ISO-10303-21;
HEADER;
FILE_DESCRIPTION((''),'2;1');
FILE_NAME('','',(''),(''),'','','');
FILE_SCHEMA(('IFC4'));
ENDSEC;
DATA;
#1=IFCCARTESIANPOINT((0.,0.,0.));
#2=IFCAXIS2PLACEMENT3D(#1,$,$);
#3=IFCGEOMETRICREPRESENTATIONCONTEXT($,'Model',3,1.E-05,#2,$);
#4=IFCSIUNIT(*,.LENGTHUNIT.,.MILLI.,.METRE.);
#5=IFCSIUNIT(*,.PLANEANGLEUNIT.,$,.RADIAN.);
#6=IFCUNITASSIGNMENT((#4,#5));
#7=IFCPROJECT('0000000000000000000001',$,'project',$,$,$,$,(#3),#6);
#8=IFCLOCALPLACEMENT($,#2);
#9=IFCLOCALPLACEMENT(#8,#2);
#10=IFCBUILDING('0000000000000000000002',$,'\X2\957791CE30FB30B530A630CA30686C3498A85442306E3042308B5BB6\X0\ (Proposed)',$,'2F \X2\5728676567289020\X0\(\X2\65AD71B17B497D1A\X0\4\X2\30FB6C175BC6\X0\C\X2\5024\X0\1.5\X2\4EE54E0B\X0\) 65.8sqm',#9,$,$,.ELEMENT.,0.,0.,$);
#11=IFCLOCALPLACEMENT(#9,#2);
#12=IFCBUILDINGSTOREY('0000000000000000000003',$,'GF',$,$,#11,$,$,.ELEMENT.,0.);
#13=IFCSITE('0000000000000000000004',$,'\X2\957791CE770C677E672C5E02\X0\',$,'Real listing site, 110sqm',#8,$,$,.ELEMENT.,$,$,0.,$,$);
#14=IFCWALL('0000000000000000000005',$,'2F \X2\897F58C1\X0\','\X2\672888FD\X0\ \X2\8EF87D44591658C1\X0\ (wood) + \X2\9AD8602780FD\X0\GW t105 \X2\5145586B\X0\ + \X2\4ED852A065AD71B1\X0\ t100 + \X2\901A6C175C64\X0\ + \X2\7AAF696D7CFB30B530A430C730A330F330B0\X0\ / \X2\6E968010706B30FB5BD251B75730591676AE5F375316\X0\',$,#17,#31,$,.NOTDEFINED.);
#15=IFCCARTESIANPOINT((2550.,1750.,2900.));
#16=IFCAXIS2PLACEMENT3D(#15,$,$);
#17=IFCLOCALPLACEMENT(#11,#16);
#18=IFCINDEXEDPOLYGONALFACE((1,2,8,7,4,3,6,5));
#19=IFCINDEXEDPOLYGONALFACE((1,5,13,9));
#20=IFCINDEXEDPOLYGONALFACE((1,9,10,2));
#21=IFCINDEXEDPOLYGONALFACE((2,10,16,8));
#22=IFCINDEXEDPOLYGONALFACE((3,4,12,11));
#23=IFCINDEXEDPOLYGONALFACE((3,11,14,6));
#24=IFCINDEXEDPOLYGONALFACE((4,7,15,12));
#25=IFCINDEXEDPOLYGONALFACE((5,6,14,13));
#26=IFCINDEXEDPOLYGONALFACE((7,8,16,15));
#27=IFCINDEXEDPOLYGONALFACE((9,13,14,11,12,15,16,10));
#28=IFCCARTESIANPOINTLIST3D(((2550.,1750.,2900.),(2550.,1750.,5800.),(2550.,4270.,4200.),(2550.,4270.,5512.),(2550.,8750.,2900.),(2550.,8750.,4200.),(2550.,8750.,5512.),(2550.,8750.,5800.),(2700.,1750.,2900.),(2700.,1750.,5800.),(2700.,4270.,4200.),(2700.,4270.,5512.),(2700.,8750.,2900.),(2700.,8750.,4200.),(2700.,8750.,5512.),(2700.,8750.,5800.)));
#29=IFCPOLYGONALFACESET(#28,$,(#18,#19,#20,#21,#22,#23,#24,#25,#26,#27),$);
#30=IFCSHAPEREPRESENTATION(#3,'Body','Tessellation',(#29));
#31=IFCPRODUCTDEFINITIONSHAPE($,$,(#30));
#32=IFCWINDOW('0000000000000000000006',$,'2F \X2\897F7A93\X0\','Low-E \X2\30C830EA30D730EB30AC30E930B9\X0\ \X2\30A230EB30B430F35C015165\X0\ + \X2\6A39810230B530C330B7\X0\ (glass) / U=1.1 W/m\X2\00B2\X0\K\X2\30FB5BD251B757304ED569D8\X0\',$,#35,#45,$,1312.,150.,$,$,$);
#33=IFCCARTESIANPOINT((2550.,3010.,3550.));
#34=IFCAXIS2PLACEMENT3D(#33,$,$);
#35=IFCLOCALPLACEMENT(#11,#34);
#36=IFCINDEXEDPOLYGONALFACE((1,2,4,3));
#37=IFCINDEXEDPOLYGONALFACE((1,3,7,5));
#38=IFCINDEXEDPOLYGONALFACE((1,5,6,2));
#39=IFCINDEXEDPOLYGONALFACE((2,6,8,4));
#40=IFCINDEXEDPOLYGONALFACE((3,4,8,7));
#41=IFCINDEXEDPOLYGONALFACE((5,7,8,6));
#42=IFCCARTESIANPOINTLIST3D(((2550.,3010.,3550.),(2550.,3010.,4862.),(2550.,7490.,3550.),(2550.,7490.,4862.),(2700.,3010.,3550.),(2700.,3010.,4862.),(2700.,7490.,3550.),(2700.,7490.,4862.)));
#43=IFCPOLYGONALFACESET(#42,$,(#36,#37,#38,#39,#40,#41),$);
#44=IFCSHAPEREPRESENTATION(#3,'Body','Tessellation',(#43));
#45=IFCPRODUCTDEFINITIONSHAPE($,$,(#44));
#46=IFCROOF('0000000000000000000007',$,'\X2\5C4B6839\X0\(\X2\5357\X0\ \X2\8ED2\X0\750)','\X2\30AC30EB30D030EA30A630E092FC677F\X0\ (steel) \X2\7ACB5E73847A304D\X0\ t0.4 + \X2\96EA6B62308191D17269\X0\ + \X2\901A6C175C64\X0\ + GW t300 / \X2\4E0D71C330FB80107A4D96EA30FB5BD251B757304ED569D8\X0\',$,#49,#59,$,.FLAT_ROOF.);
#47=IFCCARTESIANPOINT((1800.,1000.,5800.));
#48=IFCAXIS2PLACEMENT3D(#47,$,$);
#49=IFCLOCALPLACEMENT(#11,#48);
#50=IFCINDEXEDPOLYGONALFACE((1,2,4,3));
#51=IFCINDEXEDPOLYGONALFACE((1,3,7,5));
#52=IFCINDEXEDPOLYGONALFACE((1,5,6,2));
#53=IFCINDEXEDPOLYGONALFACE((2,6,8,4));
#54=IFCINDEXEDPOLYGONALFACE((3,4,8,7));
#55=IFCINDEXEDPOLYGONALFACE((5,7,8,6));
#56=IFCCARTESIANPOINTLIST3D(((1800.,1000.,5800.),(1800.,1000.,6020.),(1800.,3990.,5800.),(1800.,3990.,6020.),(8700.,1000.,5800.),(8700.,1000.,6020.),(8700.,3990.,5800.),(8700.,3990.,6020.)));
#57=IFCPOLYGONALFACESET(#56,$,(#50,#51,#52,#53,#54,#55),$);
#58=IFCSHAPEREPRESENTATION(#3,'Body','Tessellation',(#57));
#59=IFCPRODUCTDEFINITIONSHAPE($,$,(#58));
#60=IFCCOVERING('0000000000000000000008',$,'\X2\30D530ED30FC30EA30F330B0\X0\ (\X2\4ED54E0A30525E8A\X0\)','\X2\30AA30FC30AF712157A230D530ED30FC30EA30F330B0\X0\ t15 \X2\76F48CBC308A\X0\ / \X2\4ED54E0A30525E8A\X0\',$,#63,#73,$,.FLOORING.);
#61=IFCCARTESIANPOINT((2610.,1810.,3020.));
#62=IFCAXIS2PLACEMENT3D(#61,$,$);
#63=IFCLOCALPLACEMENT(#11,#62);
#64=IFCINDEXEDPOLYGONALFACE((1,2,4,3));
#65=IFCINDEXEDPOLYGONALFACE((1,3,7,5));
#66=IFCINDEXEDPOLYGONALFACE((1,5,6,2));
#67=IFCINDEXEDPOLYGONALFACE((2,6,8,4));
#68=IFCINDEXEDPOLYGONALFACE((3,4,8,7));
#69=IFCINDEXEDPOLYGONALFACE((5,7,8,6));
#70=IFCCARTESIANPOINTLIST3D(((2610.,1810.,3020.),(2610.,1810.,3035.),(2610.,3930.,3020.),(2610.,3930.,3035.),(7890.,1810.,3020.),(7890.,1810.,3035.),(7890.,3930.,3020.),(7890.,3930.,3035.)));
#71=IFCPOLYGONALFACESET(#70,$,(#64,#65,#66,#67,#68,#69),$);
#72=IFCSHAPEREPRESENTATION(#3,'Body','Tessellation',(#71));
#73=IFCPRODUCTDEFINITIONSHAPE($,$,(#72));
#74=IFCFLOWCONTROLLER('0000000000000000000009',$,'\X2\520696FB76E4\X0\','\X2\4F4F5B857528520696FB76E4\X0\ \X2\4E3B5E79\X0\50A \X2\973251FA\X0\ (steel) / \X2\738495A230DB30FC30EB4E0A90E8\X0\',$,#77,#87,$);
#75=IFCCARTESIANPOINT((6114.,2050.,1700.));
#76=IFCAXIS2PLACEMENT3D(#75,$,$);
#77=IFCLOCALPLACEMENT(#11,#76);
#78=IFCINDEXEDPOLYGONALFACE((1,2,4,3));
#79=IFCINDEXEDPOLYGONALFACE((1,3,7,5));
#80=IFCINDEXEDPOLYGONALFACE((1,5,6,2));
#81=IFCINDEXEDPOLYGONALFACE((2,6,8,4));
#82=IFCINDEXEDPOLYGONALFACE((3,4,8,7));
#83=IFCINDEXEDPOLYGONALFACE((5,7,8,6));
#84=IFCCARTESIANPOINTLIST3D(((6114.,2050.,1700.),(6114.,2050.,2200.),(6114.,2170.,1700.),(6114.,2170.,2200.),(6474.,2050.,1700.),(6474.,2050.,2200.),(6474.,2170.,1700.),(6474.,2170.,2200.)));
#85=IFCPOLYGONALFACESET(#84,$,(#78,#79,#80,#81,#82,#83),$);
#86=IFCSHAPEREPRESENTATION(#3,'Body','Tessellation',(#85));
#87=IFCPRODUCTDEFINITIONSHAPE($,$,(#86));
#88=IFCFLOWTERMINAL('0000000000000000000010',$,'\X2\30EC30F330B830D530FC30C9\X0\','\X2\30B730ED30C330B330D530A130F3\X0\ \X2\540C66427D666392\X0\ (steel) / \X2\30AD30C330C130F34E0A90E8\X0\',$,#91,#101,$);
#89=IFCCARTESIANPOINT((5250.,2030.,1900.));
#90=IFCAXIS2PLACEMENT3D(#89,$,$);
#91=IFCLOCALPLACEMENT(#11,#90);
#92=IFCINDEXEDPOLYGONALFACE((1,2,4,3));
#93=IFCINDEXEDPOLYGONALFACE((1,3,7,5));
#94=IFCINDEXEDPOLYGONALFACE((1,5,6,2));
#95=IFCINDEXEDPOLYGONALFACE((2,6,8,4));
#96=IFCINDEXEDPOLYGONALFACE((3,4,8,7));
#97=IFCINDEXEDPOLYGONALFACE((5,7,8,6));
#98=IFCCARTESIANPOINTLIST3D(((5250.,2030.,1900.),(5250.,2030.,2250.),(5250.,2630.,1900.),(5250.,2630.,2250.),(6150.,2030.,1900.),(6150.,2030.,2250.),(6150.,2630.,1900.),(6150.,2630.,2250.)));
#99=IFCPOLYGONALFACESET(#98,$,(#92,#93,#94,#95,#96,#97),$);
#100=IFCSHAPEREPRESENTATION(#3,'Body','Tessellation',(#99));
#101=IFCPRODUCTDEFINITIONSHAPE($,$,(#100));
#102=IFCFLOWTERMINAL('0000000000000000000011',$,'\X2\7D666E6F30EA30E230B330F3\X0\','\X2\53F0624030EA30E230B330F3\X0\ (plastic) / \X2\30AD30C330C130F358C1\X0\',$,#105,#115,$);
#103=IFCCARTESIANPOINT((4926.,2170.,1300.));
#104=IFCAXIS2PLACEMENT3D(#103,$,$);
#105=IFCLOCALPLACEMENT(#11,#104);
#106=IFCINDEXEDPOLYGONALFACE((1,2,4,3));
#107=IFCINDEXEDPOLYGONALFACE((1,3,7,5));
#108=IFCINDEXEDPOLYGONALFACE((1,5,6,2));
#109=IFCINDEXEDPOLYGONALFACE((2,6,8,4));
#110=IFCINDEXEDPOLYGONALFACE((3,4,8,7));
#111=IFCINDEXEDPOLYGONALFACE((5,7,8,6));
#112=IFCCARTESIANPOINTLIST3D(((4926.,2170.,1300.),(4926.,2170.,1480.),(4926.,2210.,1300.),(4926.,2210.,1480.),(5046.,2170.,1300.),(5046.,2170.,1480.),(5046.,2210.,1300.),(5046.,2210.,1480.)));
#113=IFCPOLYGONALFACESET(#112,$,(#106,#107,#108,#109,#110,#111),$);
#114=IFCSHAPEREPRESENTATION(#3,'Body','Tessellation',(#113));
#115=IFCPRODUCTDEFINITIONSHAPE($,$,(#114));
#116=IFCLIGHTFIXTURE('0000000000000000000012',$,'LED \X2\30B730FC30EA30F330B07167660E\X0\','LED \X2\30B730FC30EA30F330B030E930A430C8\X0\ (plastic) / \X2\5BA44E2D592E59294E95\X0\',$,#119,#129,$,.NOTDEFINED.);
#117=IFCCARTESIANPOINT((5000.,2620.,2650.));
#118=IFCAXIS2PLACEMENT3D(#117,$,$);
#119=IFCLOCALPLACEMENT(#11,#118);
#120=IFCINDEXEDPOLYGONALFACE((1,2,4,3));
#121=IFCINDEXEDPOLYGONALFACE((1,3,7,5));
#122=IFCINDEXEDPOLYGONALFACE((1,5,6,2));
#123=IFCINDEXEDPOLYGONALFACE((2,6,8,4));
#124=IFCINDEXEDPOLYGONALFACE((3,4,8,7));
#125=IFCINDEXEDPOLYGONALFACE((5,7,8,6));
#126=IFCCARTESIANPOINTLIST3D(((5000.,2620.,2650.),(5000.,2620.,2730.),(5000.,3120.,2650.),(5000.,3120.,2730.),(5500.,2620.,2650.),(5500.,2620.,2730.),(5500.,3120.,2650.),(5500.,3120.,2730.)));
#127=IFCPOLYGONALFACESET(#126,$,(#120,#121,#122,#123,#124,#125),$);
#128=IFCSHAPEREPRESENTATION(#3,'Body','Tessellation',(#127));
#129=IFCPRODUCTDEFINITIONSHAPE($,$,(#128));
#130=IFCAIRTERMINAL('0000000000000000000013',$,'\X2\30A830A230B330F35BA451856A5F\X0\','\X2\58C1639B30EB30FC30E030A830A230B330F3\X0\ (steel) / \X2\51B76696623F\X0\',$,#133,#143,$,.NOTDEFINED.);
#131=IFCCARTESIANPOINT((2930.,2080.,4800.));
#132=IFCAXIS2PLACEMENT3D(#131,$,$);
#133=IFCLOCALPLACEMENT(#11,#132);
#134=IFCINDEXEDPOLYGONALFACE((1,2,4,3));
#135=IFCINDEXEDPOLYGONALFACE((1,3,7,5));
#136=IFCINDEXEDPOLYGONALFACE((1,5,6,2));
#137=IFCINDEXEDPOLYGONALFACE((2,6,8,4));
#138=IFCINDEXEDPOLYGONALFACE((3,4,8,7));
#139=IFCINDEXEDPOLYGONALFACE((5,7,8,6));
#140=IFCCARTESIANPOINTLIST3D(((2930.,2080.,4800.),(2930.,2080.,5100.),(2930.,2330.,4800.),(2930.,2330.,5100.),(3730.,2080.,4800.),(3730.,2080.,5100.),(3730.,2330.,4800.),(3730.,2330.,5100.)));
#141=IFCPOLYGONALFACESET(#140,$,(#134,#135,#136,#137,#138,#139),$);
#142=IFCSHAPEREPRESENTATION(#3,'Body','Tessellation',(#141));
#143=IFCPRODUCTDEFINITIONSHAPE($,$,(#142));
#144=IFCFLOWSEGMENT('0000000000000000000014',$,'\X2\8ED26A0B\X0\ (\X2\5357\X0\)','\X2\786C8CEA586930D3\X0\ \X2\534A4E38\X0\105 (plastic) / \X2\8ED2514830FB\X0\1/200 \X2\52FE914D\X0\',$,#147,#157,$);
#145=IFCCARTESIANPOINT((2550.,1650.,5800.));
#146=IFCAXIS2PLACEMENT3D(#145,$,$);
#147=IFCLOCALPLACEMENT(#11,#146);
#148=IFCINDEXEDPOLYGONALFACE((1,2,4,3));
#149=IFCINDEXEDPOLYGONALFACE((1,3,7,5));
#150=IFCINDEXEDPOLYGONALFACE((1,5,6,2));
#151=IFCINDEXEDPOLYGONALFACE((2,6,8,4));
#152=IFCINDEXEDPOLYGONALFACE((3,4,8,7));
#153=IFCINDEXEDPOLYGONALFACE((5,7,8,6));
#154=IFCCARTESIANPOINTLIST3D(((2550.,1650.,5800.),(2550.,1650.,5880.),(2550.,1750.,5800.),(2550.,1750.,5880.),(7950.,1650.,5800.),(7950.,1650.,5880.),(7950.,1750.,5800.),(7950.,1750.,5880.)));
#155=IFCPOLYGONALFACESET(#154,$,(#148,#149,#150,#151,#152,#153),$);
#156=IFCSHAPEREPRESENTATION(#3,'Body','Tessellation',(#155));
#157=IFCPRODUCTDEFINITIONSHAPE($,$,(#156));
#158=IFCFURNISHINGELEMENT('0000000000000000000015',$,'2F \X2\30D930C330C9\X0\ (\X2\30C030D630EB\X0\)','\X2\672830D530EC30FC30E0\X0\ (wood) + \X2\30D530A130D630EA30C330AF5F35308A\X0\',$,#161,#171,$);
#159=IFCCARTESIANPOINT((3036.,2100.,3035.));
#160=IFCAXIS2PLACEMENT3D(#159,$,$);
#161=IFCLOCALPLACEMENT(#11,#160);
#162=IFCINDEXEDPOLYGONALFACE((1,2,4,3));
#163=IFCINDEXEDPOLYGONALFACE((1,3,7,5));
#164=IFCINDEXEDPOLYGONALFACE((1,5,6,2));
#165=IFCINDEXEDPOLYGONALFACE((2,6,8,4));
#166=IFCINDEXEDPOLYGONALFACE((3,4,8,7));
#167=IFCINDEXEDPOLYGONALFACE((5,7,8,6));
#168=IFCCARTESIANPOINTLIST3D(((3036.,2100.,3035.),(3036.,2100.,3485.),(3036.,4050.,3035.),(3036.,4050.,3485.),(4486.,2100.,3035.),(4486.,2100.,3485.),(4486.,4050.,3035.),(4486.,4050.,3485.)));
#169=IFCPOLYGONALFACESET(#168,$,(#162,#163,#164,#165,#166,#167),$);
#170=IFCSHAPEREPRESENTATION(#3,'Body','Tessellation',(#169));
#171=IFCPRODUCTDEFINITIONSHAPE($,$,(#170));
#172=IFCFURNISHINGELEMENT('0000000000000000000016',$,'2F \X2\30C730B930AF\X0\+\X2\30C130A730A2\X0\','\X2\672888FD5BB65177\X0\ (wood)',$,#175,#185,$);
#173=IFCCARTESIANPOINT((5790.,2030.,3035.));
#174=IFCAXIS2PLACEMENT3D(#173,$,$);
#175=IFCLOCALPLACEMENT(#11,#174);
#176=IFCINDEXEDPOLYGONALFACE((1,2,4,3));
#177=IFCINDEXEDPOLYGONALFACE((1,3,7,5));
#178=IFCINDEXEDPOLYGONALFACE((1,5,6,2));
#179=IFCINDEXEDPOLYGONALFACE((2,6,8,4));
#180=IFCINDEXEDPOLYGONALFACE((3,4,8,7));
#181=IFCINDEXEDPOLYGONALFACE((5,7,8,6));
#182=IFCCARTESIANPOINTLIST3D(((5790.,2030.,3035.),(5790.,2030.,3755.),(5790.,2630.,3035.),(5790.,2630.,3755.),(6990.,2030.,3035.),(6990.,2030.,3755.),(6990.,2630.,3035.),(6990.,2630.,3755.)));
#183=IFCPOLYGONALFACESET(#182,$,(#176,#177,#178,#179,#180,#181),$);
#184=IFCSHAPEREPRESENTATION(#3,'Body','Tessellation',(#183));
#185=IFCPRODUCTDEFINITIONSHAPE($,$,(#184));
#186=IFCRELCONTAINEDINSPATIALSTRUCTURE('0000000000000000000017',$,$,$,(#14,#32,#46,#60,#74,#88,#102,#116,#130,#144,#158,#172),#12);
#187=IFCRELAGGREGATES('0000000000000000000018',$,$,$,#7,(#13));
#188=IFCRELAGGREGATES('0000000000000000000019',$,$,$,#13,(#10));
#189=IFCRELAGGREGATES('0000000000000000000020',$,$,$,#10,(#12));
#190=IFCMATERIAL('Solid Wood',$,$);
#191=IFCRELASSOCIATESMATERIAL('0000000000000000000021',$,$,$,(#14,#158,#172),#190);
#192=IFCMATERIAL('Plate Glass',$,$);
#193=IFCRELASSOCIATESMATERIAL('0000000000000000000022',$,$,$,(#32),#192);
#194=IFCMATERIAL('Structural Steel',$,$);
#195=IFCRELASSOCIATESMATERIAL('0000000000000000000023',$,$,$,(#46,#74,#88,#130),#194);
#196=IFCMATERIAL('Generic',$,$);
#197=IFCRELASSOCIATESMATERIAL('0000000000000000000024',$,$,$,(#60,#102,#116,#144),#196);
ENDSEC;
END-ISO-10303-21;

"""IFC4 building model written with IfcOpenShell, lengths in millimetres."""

from ifc_helpers import new_model, si_unit, frame, frame_2d, origin, place, context, project, spatial, rectangle, extrude, material, element, fill, save


model = new_model("IFC4")

# Units and contexts
model_context = context("Model", 3, precision=1e-05, world=origin())
ifc_project = project(units=[si_unit("LENGTHUNIT", "METRE", prefix="MILLI"), si_unit("PLANEANGLEUNIT", "RADIAN")], contexts=[model_context])

# Site, building, storey
site_placement = place(None, origin())
site = spatial("IfcSite", under=ifc_project, at=site_placement, Name="長野県松本市", ObjectType="Real listing site, 110sqm", CompositionType="ELEMENT", RefElevation=0.0)
building_placement = place(site_placement, origin())
building = spatial("IfcBuilding", under=site, at=building_placement, Name="長野・サウナと水風呂のある家 (Proposed)", ObjectType="2F 在来木造(断熱等級4・気密C値1.5以下) 65.8sqm", CompositionType="ELEMENT", ElevationOfRefHeight=0.0, ElevationOfTerrain=0.0)
storey_placement = place(building_placement, origin())
storey = spatial("IfcBuildingStorey", under=building, at=storey_placement, Name="GF", CompositionType="ELEMENT", Elevation=0.0)

# Shared definitions
ifc_material_1 = material(Name="Solid Wood")

# Wall, opening, window
ifc_material_2 = material(Name="Plate Glass")
wall_1_placement = place(storey_placement, frame((2550.0, 1750.0, 2900.0)))
wall_1 = element("IfcWall", 1, at=wall_1_placement, inside=storey, material=ifc_material_1, Name="2F 西壁", Description="木製 軸組外壁 (wood) + 高性能GW t105 充填 + 付加断熱 t100 + 通気層 + 窯業系サイディング / 準耐火・寒冷地外皮強化", PredefinedType="NOTDEFINED", context=model_context, shape_type="SweptSolid", body=[
    extrude(rectangle(XDim=150.0, YDim=7000.0, at=frame_2d((75.0, 3500.0))), frame((2550.0, 1750.0, 2900.0)), (0.0, 0.0, 1.0), 2900.0),
])
opening_1_placement = place(storey_placement, frame((2550.0, 3010.0, 3550.0)))
opening_1 = element("IfcOpeningElement", 2, at=opening_1_placement, cuts=wall_1, PredefinedType="NOTDEFINED", context=model_context, shape_type="SweptSolid", body=[
    extrude(rectangle(XDim=150.0, YDim=4480.0, at=frame_2d((75.0, 2240.0))), frame((2550.0, 3010.0, 3550.0)), (0.0, 0.0, 1.0), 1312.0),
])
window_1_placement = place(storey_placement, frame((2550.0, 3010.0, 3550.0)))
window_1 = element("IfcWindow", 3, at=window_1_placement, inside=storey, material=ifc_material_2, Name="2F 西窓", Description="Low-E トリプルガラス アルゴン封入 + 樹脂サッシ (glass) / U=1.1 W/m²K・寒冷地仕様", OverallHeight=1312.0, OverallWidth=150.0, context=model_context, shape_type="SweptSolid", body=[
    extrude(rectangle(XDim=150.0, YDim=4480.0, at=frame_2d((75.0, 2240.0))), frame((2550.0, 3010.0, 3550.0)), (0.0, 0.0, 1.0), 1312.0),
])
fill(opening_1, window_1)

# Roof
ifc_material_3 = material(Name="Structural Steel")
for number, where, name in (
    (4, (1800.0, 1000.0, 5800.0), "屋根(南 軒750)"),
):
    element("IfcRoof", number, at=place(storey_placement, frame(where)), inside=storey, material=ifc_material_3, Name=name, Description="ガルバリウム鋼板 (steel) 立平葺き t0.4 + 雪止め金物 + 通気層 + GW t300 / 不燃・耐積雪・寒冷地仕様", PredefinedType="FLAT_ROOF", context=model_context, shape_type="SweptSolid", body=[
        extrude(rectangle(XDim=6900.0, YDim=2990.0, at=frame_2d((3450.0, 1495.0))), frame((1800.0, 1000.0, 5800.0)), (0.0, 0.0, 1.0), 220.0),
    ])

# Covering
ifc_material_4 = material(Name="Generic")
covering_placement = place(storey_placement, frame((2610.0, 1810.0, 3020.0)))
element("IfcCovering", 5, at=covering_placement, inside=storey, material=ifc_material_4, Name="フローリング (仕上げ床)", Description="オーク無垢フローリング t15 直貼り / 仕上げ床", PredefinedType="FLOORING", context=model_context, shape_type="SweptSolid", body=[
    extrude(rectangle(XDim=5280.0, YDim=2120.0, at=frame_2d((2640.0, 1060.0))), frame((2610.0, 1810.0, 3020.0)), (0.0, 0.0, 1.0), 15.0),
])

# Flow controller
flow_controller_placement = place(storey_placement, frame((6114.0, 2050.0, 1700.0)))
element("IfcFlowController", 6, at=flow_controller_placement, inside=storey, material=ifc_material_3, Name="分電盤", Description="住宅用分電盤 主幹50A 露出 (steel) / 玄関ホール上部", context=model_context, shape_type="SweptSolid", body=[
    extrude(rectangle(XDim=360.0, YDim=120.0, at=frame_2d((180.0, 60.0))), frame((6114.0, 2050.0, 1700.0)), (0.0, 0.0, 1.0), 500.0),
])

# Flow terminals
flow_terminal_1_placement = place(storey_placement, frame((5250.0, 2030.0, 1900.0)))
element("IfcFlowTerminal", 7, at=flow_terminal_1_placement, inside=storey, material=ifc_material_3, Name="レンジフード", Description="シロッコファン 同時給排 (steel) / キッチン上部", context=model_context, shape_type="SweptSolid", body=[
    extrude(rectangle(XDim=900.0, YDim=600.0, at=frame_2d((450.0, 300.0))), frame((5250.0, 2030.0, 1900.0)), (0.0, 0.0, 1.0), 350.0),
])
flow_terminal_2_placement = place(storey_placement, frame((4926.0, 2170.0, 1300.0)))
element("IfcFlowTerminal", 8, at=flow_terminal_2_placement, inside=storey, material=ifc_material_4, Name="給湯リモコン", Description="台所リモコン (plastic) / キッチン壁", context=model_context, shape_type="SweptSolid", body=[
    extrude(rectangle(XDim=120.0, YDim=40.0, at=frame_2d((60.0, 20.0))), frame((4926.0, 2170.0, 1300.0)), (0.0, 0.0, 1.0), 180.0),
])

# Light fixture
light_fixture_placement = place(storey_placement, frame((5000.0, 2620.0, 2650.0)))
element("IfcLightFixture", 9, at=light_fixture_placement, inside=storey, material=ifc_material_4, Name="LED シーリング照明", Description="LED シーリングライト (plastic) / 室中央天井", PredefinedType="NOTDEFINED", context=model_context, shape_type="SweptSolid", body=[
    extrude(rectangle(XDim=500.0, YDim=500.0, at=frame_2d((250.0, 250.0))), frame((5000.0, 2620.0, 2650.0)), (0.0, 0.0, 1.0), 80.0),
])

# Air terminal
air_terminal_placement = place(storey_placement, frame((2930.0, 2080.0, 4800.0)))
element("IfcAirTerminal", 10, at=air_terminal_placement, inside=storey, material=ifc_material_3, Name="エアコン室内機", Description="壁掛ルームエアコン (steel) / 冷暖房", PredefinedType="NOTDEFINED", context=model_context, shape_type="SweptSolid", body=[
    extrude(rectangle(XDim=800.0, YDim=250.0, at=frame_2d((400.0, 125.0))), frame((2930.0, 2080.0, 4800.0)), (0.0, 0.0, 1.0), 300.0),
])

# Flow segment
flow_segment_placement = place(storey_placement, frame((2550.0, 1650.0, 5800.0)))
element("IfcFlowSegment", 11, at=flow_segment_placement, inside=storey, material=ifc_material_4, Name="軒樋 (南)", Description="硬質塩ビ 半丸105 (plastic) / 軒先・1/200 勾配", context=model_context, shape_type="SweptSolid", body=[
    extrude(rectangle(XDim=5400.0, YDim=100.0, at=frame_2d((2700.0, 50.0))), frame((2550.0, 1650.0, 5800.0)), (0.0, 0.0, 1.0), 80.0),
])

# Furnishing elements
furnishing_1_placement = place(storey_placement, frame((3036.0, 2100.0, 3035.0)))
element("IfcFurnishingElement", 12, at=furnishing_1_placement, inside=storey, material=ifc_material_1, Name="2F ベッド (ダブル)", Description="木フレーム (wood) + ファブリック張り", context=model_context, shape_type="SweptSolid", body=[
    extrude(rectangle(XDim=1450.0, YDim=1950.0, at=frame_2d((725.0, 975.0))), frame((3036.0, 2100.0, 3035.0)), (0.0, 0.0, 1.0), 450.0),
])
furnishing_2_placement = place(storey_placement, frame((5790.0, 2030.0, 3035.0)))
element("IfcFurnishingElement", 13, at=furnishing_2_placement, inside=storey, material=ifc_material_1, Name="2F デスク+チェア", Description="木製家具 (wood)", context=model_context, shape_type="SweptSolid", body=[
    extrude(rectangle(XDim=1200.0, YDim=600.0, at=frame_2d((600.0, 300.0))), frame((5790.0, 2030.0, 3035.0)), (0.0, 0.0, 1.0), 720.0),
])

save(model, "model.ifc")
